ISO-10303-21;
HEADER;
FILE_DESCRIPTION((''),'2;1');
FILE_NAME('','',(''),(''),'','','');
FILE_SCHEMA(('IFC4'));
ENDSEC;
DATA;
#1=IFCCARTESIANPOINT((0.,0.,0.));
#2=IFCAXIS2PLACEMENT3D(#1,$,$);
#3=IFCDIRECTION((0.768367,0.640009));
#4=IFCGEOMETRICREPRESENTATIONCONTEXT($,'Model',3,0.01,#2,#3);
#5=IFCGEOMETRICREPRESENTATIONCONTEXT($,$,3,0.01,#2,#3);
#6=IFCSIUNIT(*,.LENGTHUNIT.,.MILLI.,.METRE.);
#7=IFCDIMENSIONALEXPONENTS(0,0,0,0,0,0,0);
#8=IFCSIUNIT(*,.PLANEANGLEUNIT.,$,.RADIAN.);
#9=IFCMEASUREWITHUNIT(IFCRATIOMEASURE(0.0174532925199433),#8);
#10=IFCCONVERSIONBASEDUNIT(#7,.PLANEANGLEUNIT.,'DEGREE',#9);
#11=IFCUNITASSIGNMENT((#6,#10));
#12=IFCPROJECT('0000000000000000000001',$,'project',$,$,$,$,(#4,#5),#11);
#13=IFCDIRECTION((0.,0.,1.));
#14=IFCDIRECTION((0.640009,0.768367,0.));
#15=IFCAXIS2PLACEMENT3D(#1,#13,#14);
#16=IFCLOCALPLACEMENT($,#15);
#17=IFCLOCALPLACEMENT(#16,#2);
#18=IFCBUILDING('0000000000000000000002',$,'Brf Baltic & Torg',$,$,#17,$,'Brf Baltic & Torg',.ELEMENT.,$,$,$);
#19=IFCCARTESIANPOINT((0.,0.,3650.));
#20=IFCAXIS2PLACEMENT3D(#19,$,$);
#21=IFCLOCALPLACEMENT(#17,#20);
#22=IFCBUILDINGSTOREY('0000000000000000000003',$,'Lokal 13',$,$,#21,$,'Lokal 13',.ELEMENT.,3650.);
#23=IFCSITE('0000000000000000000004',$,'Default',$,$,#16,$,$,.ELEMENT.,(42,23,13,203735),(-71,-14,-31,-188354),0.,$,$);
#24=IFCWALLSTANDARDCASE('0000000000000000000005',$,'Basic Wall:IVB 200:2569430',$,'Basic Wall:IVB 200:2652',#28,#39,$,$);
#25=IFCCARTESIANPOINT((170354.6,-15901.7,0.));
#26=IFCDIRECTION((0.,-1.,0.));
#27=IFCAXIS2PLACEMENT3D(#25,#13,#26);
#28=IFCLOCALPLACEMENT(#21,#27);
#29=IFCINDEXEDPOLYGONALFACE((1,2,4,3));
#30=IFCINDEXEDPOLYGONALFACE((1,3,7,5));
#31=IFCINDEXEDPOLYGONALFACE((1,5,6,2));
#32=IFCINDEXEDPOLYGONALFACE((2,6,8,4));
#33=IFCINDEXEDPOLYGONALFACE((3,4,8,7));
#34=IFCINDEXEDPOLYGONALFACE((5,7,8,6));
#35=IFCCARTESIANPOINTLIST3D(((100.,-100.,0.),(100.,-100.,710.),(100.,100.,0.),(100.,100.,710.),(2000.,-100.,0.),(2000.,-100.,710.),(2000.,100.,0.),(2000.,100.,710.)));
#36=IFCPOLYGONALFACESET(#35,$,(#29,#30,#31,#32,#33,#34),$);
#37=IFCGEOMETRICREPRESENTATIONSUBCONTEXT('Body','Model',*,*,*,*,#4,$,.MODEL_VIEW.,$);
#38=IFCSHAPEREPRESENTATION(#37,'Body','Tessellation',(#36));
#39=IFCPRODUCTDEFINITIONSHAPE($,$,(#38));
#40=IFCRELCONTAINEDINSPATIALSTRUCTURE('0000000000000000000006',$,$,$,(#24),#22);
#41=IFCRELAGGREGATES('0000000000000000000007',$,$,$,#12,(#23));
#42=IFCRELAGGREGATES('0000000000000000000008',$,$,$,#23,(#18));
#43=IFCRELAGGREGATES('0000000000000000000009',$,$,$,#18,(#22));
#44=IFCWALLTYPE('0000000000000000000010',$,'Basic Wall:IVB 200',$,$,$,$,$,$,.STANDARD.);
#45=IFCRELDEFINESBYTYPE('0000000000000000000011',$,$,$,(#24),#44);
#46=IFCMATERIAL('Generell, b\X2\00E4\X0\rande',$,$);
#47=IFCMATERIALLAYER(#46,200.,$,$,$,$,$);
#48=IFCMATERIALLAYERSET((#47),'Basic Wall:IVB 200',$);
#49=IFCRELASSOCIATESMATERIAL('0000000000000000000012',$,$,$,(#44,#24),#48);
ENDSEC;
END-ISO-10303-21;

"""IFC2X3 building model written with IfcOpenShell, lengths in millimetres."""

from ifc_helpers import new_model, entity, si_unit, converted_unit, direction, frame, frame_2d, origin, place, context, subcontext, project, spatial, rectangle, extrude, clip, halfspace, material, layer, layer_set, layer_usage, type_object, element, save


model = new_model("IFC2X3")

# Units and contexts
model_context = context("Model", 3, precision=0.01, world=origin(), true_north=direction((0.768367, 0.640009)))
context_of_model = context(None, 3, precision=0.01, world=origin(), true_north=direction((0.768367, 0.640009)))
body_context = subcontext(model_context, "Body", "Model", "MODEL_VIEW")
ifc_project = project(units=[si_unit("LENGTHUNIT", "METRE", prefix="MILLI"), converted_unit("PLANEANGLEUNIT", "DEGREE", entity("IfcRatioMeasure", 0.0174532925199433), si_unit("PLANEANGLEUNIT", "RADIAN"), dimensions=[0, 0, 0, 0, 0, 0, 0])], contexts=[model_context, context_of_model])

# Site, building, storey
site_placement = place(None, frame((0.0, 0.0, 0.0), z_axis=(0.0, 0.0, 1.0), x_axis=(0.640009, 0.768367, 0.0)))
site = spatial("IfcSite", under=ifc_project, at=site_placement, Name="Default", CompositionType="ELEMENT", RefLatitude=(42, 23, 13, 203735), RefLongitude=(-71, -14, -31, -188354), RefElevation=0.0)
building_placement = place(site_placement, origin())
building = spatial("IfcBuilding", under=site, at=building_placement, Name="Brf Baltic & Torg", LongName="Brf Baltic & Torg", CompositionType="ELEMENT")
storey_placement = place(building_placement, frame((0.0, 0.0, 3650.0)))
storey = spatial("IfcBuildingStorey", under=building, at=storey_placement, Name="Lokal 13", LongName="Lokal 13", CompositionType="ELEMENT", Elevation=3650.0)

# Wall, opening
ifc_material = material(Name="Generell, bärande")
ifc_layer_1 = layer(ifc_material, 200.0)
ifc_layer_set_1 = layer_set([ifc_layer_1], Name="Basic Wall:IVB 200")
ifc_layer_usage_1 = layer_usage(ifc_layer_set_1, "AXIS2", "NEGATIVE", 100.0)
wall_type_1 = type_object("IfcWallType", Name="Basic Wall:IVB 200", PredefinedType="STANDARD", material=ifc_layer_set_1)
wall_1_placement = place(storey_placement, frame((170354.6, -15901.7, 0.0), z_axis=(0.0, 0.0, 1.0), x_axis=(0.0, -1.0, 0.0)))
wall_1 = element("IfcWallStandardCase", 1, at=wall_1_placement, inside=storey, type_object=wall_type_1, material=ifc_layer_usage_1, Name="Basic Wall:IVB 200:2569430", ObjectType="Basic Wall:IVB 200:2652", context=body_context, shape_type="Clipping", body=[
    clip(extrude(rectangle(XDim=1900.0, YDim=200.0, at=frame_2d((1050.0, 0.0), x_axis=(-1.0, 0.0))), origin(), (0.0, 0.0, 1.0), 710.0), halfspace(frame((0.0, 0.0, -2000.0)), True)),
])
opening_1_placement = place(wall_1_placement, origin())
element("IfcOpeningElement", 2, at=opening_1_placement, cuts=wall_1, ObjectType="Opening", context=body_context, shape_type="SweptSolid", body=[
    extrude(rectangle(XDim=2500.0, YDim=200.0, at=frame_2d((0.0, 0.0), x_axis=(0.0, 1.0))), frame((100.0, 100.0, 920.0), z_axis=(0.0, 1.0, 0.0), x_axis=(1.0, 0.0, 0.0)), (0.0, 0.0, 1.0), 2020.0),
])

save(model, "model.ifc")
